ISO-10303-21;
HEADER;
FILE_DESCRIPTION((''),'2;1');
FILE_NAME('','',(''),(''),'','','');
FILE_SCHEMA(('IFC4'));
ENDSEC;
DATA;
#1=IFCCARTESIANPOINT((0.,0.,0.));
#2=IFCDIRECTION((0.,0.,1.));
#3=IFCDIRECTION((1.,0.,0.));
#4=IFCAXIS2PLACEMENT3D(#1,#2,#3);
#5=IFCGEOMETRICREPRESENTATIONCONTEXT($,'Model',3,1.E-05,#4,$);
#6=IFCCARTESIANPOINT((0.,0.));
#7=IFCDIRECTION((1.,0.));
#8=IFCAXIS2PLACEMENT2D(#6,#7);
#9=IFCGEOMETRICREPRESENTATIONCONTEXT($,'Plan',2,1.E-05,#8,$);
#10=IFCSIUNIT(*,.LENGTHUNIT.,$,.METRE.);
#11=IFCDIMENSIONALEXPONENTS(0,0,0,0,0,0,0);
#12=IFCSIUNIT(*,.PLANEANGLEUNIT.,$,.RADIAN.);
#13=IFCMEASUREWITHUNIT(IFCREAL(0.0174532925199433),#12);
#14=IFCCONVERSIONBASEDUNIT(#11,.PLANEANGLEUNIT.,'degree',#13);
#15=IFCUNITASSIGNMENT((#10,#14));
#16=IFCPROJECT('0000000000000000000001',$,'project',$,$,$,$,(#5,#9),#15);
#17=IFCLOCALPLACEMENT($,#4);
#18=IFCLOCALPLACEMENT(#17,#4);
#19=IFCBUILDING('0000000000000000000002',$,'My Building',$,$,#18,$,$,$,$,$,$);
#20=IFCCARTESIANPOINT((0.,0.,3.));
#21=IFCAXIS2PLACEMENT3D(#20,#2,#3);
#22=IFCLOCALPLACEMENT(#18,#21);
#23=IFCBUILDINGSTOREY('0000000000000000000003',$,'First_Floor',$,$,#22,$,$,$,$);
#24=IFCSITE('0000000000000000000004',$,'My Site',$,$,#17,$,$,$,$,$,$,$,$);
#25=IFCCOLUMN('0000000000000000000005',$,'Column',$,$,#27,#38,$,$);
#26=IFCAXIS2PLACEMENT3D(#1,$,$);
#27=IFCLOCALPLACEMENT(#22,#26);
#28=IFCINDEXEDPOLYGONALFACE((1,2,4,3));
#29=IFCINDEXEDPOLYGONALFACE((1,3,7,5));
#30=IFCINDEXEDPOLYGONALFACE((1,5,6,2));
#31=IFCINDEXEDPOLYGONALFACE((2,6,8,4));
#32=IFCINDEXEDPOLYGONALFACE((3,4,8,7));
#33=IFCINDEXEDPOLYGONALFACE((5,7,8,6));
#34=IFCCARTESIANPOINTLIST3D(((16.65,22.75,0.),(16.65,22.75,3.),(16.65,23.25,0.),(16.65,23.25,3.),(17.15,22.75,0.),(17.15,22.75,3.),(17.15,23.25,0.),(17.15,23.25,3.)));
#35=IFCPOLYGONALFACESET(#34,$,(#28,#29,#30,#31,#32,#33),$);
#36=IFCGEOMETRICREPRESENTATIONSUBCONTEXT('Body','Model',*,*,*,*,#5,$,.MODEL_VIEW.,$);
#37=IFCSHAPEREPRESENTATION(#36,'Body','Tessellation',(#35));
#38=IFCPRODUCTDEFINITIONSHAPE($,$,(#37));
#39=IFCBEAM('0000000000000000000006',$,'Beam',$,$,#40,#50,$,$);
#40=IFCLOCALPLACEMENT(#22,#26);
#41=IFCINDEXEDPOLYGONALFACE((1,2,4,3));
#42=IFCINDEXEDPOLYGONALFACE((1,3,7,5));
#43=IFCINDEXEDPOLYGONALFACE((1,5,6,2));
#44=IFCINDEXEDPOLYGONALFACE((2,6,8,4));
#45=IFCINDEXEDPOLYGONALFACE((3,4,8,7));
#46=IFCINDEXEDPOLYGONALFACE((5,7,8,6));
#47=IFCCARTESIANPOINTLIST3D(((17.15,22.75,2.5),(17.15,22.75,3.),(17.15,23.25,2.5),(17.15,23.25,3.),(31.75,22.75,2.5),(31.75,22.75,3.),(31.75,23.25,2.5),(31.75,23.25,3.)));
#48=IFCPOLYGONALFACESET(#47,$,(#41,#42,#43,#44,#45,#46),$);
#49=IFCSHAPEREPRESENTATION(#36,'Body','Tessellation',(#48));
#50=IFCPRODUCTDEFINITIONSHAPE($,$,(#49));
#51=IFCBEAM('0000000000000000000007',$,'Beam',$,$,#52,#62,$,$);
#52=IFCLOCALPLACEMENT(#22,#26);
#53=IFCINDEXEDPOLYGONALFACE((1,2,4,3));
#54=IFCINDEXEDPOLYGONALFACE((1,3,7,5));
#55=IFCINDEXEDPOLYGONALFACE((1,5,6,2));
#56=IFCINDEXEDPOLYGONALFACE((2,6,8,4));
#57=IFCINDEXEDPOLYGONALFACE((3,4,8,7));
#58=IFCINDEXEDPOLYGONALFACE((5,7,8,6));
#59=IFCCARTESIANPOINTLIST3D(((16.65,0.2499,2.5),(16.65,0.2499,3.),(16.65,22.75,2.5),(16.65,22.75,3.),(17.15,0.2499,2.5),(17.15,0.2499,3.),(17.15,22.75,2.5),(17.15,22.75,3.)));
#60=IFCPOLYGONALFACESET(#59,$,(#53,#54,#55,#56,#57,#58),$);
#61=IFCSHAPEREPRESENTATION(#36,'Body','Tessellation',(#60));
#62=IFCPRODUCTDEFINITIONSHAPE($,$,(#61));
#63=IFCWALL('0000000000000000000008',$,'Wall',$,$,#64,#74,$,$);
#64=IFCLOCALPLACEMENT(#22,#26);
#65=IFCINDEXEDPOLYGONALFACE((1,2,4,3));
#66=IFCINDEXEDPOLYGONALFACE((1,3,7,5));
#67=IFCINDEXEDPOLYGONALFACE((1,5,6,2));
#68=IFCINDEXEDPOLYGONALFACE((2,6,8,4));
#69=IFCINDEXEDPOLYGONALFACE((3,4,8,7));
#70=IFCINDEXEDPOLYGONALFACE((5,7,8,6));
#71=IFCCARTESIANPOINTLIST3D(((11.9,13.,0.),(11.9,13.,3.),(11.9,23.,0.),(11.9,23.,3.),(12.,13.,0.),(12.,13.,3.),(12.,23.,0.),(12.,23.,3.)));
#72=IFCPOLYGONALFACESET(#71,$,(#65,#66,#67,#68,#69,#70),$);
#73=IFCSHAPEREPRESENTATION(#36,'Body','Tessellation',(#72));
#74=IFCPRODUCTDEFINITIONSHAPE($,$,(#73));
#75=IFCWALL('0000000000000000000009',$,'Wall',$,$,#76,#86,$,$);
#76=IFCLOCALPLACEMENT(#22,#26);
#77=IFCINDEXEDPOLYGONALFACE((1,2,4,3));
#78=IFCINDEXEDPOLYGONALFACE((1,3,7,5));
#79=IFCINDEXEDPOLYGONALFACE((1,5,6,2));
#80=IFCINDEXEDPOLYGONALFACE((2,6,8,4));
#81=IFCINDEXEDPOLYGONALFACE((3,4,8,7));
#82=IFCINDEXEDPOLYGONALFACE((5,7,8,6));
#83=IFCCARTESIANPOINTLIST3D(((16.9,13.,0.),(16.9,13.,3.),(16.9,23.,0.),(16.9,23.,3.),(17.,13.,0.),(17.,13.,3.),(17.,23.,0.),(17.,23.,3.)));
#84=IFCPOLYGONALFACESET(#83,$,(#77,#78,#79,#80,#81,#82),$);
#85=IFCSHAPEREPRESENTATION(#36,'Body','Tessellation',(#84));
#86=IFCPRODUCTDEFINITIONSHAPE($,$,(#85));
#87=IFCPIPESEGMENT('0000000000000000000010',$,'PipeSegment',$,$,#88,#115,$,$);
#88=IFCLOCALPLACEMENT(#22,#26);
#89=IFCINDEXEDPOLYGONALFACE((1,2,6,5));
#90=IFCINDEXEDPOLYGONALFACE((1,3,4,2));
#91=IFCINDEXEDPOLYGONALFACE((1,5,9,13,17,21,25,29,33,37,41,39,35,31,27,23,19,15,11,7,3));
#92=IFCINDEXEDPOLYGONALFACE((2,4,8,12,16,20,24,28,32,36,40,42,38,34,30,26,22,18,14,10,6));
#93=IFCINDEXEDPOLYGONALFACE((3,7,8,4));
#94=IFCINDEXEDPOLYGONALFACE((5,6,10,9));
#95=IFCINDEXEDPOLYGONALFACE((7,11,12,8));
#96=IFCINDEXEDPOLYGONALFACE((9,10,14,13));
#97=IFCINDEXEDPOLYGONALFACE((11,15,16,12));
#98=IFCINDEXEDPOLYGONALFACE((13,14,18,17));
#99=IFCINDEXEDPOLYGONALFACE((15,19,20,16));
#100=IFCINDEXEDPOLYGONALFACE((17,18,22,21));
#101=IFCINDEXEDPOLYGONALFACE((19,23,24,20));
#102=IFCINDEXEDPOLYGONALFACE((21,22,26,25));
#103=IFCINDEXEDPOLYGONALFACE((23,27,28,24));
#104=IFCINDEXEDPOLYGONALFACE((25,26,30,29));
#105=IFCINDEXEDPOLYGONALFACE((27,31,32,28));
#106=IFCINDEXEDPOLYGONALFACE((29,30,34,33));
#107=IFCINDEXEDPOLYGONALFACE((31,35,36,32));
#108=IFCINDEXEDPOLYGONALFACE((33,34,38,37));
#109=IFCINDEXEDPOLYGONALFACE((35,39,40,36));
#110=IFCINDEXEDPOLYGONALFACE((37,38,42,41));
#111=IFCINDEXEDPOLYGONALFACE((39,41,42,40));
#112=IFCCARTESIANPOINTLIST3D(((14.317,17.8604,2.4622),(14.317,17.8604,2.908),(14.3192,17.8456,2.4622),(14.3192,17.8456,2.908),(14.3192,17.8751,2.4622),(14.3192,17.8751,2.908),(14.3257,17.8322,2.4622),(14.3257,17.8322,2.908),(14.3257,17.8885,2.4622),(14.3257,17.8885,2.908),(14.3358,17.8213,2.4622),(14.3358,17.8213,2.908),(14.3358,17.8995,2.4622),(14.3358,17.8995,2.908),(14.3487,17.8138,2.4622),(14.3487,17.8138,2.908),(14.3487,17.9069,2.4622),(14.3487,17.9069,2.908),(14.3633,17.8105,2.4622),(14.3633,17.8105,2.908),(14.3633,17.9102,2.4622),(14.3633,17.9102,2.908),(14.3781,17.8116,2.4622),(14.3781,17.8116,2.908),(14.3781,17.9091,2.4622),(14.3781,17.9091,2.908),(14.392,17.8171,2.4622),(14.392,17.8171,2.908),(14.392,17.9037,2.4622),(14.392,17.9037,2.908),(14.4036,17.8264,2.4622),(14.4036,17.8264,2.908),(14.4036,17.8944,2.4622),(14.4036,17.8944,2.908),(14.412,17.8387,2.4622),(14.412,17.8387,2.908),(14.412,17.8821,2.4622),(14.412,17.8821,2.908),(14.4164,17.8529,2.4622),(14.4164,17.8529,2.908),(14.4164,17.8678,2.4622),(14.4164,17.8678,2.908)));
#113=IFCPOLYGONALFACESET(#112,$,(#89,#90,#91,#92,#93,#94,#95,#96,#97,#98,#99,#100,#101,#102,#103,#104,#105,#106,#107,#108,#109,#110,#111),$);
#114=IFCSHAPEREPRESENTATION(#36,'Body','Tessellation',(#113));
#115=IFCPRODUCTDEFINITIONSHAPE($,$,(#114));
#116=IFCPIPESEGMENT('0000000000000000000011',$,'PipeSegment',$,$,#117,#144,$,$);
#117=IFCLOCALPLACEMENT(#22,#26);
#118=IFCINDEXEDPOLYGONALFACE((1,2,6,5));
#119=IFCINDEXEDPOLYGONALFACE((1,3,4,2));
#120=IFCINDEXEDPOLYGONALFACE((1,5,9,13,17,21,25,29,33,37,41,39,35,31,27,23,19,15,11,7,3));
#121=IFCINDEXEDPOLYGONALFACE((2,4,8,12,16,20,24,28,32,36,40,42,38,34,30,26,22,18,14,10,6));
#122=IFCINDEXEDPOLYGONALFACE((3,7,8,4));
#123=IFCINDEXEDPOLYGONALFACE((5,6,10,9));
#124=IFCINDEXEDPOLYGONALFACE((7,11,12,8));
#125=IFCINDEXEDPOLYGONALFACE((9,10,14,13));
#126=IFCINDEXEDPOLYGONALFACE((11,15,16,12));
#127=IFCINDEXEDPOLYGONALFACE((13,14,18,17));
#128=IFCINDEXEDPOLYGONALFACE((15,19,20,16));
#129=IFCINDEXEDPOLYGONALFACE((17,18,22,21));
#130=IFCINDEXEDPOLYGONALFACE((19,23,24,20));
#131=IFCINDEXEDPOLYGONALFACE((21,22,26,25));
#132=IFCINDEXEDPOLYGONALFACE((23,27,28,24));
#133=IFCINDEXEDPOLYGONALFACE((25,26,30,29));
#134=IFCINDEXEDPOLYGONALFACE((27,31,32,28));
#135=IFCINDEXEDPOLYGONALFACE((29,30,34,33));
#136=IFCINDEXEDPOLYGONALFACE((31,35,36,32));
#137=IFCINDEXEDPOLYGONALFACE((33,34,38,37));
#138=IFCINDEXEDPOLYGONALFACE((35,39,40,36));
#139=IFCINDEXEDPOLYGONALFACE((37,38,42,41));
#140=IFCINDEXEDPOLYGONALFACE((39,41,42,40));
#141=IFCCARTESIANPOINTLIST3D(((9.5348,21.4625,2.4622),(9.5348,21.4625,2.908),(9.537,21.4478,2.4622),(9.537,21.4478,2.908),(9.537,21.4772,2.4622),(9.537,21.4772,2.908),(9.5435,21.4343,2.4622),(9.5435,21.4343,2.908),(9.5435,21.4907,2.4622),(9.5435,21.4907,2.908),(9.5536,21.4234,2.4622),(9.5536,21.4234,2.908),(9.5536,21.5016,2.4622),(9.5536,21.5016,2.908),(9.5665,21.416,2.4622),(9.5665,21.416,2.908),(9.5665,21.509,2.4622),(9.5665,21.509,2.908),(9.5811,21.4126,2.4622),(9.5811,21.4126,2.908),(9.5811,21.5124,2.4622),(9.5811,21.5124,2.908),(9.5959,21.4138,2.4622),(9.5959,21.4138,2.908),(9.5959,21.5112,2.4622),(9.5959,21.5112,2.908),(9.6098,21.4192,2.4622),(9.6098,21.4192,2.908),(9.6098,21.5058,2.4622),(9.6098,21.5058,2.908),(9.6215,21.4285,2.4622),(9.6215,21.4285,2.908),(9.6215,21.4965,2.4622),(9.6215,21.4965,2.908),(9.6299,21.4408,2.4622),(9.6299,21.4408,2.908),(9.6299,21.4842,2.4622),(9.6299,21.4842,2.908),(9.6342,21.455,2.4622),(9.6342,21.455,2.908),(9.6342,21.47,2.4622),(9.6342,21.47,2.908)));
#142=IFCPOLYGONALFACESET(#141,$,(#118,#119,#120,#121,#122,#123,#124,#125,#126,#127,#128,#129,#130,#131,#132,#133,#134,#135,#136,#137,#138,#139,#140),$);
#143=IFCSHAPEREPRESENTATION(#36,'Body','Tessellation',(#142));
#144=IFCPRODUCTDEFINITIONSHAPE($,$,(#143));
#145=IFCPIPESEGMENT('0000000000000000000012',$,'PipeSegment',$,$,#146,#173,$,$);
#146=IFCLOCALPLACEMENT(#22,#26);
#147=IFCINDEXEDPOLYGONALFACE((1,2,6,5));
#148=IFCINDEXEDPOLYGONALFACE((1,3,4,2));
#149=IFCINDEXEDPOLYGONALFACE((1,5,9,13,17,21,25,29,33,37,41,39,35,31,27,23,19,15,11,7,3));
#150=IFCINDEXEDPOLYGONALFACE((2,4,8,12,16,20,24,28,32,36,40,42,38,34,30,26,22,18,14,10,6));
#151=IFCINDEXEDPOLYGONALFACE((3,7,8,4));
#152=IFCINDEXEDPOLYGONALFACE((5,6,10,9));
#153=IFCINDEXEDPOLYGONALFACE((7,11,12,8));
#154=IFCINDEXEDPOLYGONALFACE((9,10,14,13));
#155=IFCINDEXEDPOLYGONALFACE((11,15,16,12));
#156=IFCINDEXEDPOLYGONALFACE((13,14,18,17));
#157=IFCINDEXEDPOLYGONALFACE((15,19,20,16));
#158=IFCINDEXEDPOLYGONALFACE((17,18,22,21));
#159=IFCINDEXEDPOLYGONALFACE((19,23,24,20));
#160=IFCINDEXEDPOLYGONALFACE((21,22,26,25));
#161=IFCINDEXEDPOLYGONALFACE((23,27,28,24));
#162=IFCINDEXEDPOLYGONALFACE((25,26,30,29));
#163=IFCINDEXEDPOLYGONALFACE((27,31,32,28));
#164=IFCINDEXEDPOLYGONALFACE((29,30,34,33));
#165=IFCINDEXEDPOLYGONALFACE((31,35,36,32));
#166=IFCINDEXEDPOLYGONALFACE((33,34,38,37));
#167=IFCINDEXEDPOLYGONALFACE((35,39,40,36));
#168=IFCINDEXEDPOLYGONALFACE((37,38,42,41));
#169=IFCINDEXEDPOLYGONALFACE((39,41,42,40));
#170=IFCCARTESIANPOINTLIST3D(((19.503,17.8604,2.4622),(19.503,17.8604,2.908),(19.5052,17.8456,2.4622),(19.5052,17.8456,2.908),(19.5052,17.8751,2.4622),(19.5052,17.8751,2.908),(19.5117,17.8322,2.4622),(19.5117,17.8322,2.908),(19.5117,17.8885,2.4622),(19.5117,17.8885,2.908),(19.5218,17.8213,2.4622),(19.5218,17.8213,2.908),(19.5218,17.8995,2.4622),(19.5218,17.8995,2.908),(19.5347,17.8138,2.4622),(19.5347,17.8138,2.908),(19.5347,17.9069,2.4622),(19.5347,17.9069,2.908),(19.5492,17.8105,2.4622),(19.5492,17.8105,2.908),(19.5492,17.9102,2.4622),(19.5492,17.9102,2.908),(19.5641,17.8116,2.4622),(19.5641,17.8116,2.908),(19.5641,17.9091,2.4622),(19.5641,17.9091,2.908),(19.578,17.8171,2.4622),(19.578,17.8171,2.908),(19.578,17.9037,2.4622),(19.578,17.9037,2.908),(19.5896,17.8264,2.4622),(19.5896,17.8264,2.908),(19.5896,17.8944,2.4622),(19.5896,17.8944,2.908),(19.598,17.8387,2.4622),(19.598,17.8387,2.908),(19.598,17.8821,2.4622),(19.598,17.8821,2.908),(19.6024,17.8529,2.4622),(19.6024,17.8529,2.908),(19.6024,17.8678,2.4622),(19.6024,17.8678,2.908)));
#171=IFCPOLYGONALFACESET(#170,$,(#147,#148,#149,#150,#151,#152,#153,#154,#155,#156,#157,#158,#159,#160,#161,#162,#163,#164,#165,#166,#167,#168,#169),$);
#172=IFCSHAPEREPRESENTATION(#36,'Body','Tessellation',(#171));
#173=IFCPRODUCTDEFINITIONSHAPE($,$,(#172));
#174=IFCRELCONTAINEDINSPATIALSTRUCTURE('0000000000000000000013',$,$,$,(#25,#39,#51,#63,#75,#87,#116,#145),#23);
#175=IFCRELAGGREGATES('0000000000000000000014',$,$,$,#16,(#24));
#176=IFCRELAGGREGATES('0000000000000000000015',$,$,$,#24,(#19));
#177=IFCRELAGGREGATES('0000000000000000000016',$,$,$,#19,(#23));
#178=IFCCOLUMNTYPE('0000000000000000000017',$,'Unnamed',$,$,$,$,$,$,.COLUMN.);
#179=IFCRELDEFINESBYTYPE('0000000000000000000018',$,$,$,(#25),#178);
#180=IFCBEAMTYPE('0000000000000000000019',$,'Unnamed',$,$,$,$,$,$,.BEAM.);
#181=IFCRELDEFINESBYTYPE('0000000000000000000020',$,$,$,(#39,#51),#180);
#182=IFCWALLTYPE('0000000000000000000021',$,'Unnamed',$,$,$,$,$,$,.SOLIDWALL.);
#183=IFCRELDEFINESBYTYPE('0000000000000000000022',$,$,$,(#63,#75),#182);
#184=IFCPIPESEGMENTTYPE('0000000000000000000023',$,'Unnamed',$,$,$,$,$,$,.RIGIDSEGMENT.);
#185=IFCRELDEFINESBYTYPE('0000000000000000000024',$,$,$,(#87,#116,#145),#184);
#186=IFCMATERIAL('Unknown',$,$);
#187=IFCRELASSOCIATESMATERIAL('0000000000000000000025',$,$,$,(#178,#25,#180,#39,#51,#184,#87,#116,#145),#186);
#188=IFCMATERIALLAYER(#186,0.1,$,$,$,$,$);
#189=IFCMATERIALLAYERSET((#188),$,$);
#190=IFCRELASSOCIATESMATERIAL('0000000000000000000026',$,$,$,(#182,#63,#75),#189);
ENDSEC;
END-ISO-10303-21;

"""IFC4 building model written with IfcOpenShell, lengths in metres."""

from ifc_helpers import new_model, entity, si_unit, converted_unit, frame, origin_with_axes, origin_2d_with_axis, place, context, subcontext, project, spatial, line, indexed_curve, rectangle, circle, outline, extrude, material, layer, layer_set, layer_usage, material_profile, profile_set, profile_usage, type_object, element, save


model = new_model("IFC4")

# Units and contexts
model_context = context("Model", 3, precision=1e-05, world=origin_with_axes())
plan_context = context("Plan", 2, precision=1e-05, world=origin_2d_with_axis())
body_context = subcontext(model_context, "Body", "Model", "MODEL_VIEW")
ifc_project = project(units=[si_unit("LENGTHUNIT", "METRE"), converted_unit("PLANEANGLEUNIT", "degree", entity("IfcReal", 0.0174532925199433), si_unit("PLANEANGLEUNIT", "RADIAN"), dimensions=[0, 0, 0, 0, 0, 0, 0])], contexts=[model_context, plan_context])

# Site, building, storey
site_placement = place(None, origin_with_axes())
site = spatial("IfcSite", under=ifc_project, at=site_placement, Name="My Site")
building_placement = place(site_placement, origin_with_axes())
building = spatial("IfcBuilding", under=site, at=building_placement, Name="My Building")
storey_placement = place(building_placement, frame((0.0, 0.0, 3.0), z_axis=(0.0, 0.0, 1.0), x_axis=(1.0, 0.0, 0.0)))
storey = spatial("IfcBuildingStorey", under=building, at=storey_placement, Name="First_Floor")

# Column
ifc_material = material(Name="Unknown")
ifc_material_profile_1 = material_profile(ifc_material, rectangle(XDim=0.5, YDim=0.5))
ifc_profile_set_1 = profile_set([ifc_material_profile_1])
ifc_profile_usage_1 = profile_usage(ifc_profile_set_1, cardinal=5)
column_type = type_object("IfcColumnType", Name="Unnamed", PredefinedType="COLUMN", material=ifc_profile_set_1)
column_placement = place(storey_placement, frame((16.9, 23.0, 0.0), z_axis=(0.0, 0.0, 1.0), x_axis=(1.0, 0.0, 0.0)))
element("IfcColumn", 1, at=column_placement, inside=storey, type_object=column_type, material=ifc_profile_usage_1, Name="Column", context=body_context, shape_type="SweptSolid", body=[
    extrude(rectangle(XDim=0.5, YDim=0.5), origin_with_axes(), (0.0, 0.0, 1.0), 3.0),
])

# Beams
ifc_material_profile_2 = material_profile(ifc_material, rectangle(XDim=0.5, YDim=0.5))
ifc_profile_set_2 = profile_set([ifc_material_profile_2])
ifc_profile_usage_2 = profile_usage(ifc_profile_set_2, cardinal=6)
beam_type = type_object("IfcBeamType", Name="Unnamed", PredefinedType="BEAM", material=ifc_profile_set_2)
beam_1_placement = place(storey_placement, frame((17.15, 22.75, 2.75), z_axis=(1.0, 0.0, 0.0), x_axis=(0.0, 1.0, 0.0)))
element("IfcBeam", 2, at=beam_1_placement, inside=storey, type_object=beam_type, material=ifc_profile_usage_2, Name="Beam", context=body_context, shape_type="SweptSolid", body=[
    extrude(rectangle(XDim=0.5, YDim=0.5), frame((0.25, 0.0, 0.0), z_axis=(0.0, 0.0, 1.0), x_axis=(1.0, 0.0, 0.0)), (0.0, 0.0, 1.0), 14.6),
])
ifc_profile_usage_3 = profile_usage(ifc_profile_set_2, cardinal=5)
beam_2_placement = place(storey_placement, frame((16.9, 22.75, 2.75), z_axis=(0.0, -1.0, 0.0), x_axis=(1.0, 0.0, 0.0)))
element("IfcBeam", 3, at=beam_2_placement, inside=storey, type_object=beam_type, material=ifc_profile_usage_3, Name="Beam", context=body_context, shape_type="SweptSolid", body=[
    extrude(rectangle(XDim=0.5, YDim=0.5), origin_with_axes(), (0.0, 0.0, 1.0), 22.5001),
])

# Walls
ifc_layer = layer(ifc_material, 0.1)
ifc_layer_set = layer_set([ifc_layer])
ifc_layer_usage_1 = layer_usage(ifc_layer_set, "AXIS2", "POSITIVE", 0.0)
wall_type = type_object("IfcWallType", Name="Unnamed", PredefinedType="SOLIDWALL", material=ifc_layer_set)
wall_1_placement = place(storey_placement, frame((11.9, 23.0, 0.0), z_axis=(0.0, 0.0, 1.0), x_axis=(0.0, -1.0, 0.0)))
element("IfcWall", 4, at=wall_1_placement, inside=storey, type_object=wall_type, material=ifc_layer_usage_1, Name="Wall", context=body_context, shape_type="SweptSolid", body=[
    extrude(outline(indexed_curve([(0.0, 0.0), (0.0, 0.1), (10.0, 0.1), (10.0, 0.0)], segments=[line(1, 2, 3, 4, 1)])), origin_with_axes(), (0.0, 0.0, 1.0), 3.0),
])
ifc_layer_usage_2 = layer_usage(ifc_layer_set, "AXIS2", "POSITIVE", 0.0)
wall_2_placement = place(storey_placement, frame((16.9, 23.0, 0.0), z_axis=(0.0, 0.0, 1.0), x_axis=(0.0, -1.0, 0.0)))
element("IfcWall", 5, at=wall_2_placement, inside=storey, type_object=wall_type, material=ifc_layer_usage_2, Name="Wall", context=body_context, shape_type="SweptSolid", body=[
    extrude(outline(indexed_curve([(0.0, 0.0), (0.0, 0.1), (10.0, 0.1), (10.0, 0.0)], segments=[line(1, 2, 3, 4, 1)])), origin_with_axes(), (0.0, 0.0, 1.0), 3.0),
])

# Pipe segments
ifc_material_profile_3 = material_profile(ifc_material, circle(Radius=0.05))
ifc_profile_set_3 = profile_set([ifc_material_profile_3])
ifc_profile_usage_4 = profile_usage(ifc_profile_set_3, cardinal=5)
pipe_segment_type = type_object("IfcPipeSegmentType", Name="Unnamed", PredefinedType="RIGIDSEGMENT", material=ifc_profile_set_3)
pipe_segment_1_placement = place(storey_placement, frame((14.367, 17.8604, 2.908), z_axis=(0.0, 0.0, -1.0), x_axis=(-1.0, 0.0, 0.0)))
element("IfcPipeSegment", 6, at=pipe_segment_1_placement, inside=storey, type_object=pipe_segment_type, material=ifc_profile_usage_4, Name="PipeSegment", context=body_context, shape_type="SweptSolid", body=[
    extrude(circle(Radius=0.05), origin_with_axes(), (0.0, 0.0, 1.0), 0.4458),
])
ifc_profile_usage_5 = profile_usage(ifc_profile_set_3, cardinal=5)
pipe_segment_2_placement = place(storey_placement, frame((9.5848, 21.4625, 2.908), z_axis=(0.0, 0.0, -1.0), x_axis=(-1.0, 0.0, 0.0)))
element("IfcPipeSegment", 7, at=pipe_segment_2_placement, inside=storey, type_object=pipe_segment_type, material=ifc_profile_usage_5, Name="PipeSegment", context=body_context, shape_type="SweptSolid", body=[
    extrude(circle(Radius=0.05), origin_with_axes(), (0.0, 0.0, 1.0), 0.4458),
])
ifc_profile_usage_6 = profile_usage(ifc_profile_set_3, cardinal=5)
pipe_segment_3_placement = place(storey_placement, frame((19.553, 17.8604, 2.908), z_axis=(0.0, 0.0, -1.0), x_axis=(-1.0, 0.0, 0.0)))
element("IfcPipeSegment", 8, at=pipe_segment_3_placement, inside=storey, type_object=pipe_segment_type, material=ifc_profile_usage_6, Name="PipeSegment", context=body_context, shape_type="SweptSolid", body=[
    extrude(circle(Radius=0.05), origin_with_axes(), (0.0, 0.0, 1.0), 0.4458),
])

save(model, "model.ifc")
